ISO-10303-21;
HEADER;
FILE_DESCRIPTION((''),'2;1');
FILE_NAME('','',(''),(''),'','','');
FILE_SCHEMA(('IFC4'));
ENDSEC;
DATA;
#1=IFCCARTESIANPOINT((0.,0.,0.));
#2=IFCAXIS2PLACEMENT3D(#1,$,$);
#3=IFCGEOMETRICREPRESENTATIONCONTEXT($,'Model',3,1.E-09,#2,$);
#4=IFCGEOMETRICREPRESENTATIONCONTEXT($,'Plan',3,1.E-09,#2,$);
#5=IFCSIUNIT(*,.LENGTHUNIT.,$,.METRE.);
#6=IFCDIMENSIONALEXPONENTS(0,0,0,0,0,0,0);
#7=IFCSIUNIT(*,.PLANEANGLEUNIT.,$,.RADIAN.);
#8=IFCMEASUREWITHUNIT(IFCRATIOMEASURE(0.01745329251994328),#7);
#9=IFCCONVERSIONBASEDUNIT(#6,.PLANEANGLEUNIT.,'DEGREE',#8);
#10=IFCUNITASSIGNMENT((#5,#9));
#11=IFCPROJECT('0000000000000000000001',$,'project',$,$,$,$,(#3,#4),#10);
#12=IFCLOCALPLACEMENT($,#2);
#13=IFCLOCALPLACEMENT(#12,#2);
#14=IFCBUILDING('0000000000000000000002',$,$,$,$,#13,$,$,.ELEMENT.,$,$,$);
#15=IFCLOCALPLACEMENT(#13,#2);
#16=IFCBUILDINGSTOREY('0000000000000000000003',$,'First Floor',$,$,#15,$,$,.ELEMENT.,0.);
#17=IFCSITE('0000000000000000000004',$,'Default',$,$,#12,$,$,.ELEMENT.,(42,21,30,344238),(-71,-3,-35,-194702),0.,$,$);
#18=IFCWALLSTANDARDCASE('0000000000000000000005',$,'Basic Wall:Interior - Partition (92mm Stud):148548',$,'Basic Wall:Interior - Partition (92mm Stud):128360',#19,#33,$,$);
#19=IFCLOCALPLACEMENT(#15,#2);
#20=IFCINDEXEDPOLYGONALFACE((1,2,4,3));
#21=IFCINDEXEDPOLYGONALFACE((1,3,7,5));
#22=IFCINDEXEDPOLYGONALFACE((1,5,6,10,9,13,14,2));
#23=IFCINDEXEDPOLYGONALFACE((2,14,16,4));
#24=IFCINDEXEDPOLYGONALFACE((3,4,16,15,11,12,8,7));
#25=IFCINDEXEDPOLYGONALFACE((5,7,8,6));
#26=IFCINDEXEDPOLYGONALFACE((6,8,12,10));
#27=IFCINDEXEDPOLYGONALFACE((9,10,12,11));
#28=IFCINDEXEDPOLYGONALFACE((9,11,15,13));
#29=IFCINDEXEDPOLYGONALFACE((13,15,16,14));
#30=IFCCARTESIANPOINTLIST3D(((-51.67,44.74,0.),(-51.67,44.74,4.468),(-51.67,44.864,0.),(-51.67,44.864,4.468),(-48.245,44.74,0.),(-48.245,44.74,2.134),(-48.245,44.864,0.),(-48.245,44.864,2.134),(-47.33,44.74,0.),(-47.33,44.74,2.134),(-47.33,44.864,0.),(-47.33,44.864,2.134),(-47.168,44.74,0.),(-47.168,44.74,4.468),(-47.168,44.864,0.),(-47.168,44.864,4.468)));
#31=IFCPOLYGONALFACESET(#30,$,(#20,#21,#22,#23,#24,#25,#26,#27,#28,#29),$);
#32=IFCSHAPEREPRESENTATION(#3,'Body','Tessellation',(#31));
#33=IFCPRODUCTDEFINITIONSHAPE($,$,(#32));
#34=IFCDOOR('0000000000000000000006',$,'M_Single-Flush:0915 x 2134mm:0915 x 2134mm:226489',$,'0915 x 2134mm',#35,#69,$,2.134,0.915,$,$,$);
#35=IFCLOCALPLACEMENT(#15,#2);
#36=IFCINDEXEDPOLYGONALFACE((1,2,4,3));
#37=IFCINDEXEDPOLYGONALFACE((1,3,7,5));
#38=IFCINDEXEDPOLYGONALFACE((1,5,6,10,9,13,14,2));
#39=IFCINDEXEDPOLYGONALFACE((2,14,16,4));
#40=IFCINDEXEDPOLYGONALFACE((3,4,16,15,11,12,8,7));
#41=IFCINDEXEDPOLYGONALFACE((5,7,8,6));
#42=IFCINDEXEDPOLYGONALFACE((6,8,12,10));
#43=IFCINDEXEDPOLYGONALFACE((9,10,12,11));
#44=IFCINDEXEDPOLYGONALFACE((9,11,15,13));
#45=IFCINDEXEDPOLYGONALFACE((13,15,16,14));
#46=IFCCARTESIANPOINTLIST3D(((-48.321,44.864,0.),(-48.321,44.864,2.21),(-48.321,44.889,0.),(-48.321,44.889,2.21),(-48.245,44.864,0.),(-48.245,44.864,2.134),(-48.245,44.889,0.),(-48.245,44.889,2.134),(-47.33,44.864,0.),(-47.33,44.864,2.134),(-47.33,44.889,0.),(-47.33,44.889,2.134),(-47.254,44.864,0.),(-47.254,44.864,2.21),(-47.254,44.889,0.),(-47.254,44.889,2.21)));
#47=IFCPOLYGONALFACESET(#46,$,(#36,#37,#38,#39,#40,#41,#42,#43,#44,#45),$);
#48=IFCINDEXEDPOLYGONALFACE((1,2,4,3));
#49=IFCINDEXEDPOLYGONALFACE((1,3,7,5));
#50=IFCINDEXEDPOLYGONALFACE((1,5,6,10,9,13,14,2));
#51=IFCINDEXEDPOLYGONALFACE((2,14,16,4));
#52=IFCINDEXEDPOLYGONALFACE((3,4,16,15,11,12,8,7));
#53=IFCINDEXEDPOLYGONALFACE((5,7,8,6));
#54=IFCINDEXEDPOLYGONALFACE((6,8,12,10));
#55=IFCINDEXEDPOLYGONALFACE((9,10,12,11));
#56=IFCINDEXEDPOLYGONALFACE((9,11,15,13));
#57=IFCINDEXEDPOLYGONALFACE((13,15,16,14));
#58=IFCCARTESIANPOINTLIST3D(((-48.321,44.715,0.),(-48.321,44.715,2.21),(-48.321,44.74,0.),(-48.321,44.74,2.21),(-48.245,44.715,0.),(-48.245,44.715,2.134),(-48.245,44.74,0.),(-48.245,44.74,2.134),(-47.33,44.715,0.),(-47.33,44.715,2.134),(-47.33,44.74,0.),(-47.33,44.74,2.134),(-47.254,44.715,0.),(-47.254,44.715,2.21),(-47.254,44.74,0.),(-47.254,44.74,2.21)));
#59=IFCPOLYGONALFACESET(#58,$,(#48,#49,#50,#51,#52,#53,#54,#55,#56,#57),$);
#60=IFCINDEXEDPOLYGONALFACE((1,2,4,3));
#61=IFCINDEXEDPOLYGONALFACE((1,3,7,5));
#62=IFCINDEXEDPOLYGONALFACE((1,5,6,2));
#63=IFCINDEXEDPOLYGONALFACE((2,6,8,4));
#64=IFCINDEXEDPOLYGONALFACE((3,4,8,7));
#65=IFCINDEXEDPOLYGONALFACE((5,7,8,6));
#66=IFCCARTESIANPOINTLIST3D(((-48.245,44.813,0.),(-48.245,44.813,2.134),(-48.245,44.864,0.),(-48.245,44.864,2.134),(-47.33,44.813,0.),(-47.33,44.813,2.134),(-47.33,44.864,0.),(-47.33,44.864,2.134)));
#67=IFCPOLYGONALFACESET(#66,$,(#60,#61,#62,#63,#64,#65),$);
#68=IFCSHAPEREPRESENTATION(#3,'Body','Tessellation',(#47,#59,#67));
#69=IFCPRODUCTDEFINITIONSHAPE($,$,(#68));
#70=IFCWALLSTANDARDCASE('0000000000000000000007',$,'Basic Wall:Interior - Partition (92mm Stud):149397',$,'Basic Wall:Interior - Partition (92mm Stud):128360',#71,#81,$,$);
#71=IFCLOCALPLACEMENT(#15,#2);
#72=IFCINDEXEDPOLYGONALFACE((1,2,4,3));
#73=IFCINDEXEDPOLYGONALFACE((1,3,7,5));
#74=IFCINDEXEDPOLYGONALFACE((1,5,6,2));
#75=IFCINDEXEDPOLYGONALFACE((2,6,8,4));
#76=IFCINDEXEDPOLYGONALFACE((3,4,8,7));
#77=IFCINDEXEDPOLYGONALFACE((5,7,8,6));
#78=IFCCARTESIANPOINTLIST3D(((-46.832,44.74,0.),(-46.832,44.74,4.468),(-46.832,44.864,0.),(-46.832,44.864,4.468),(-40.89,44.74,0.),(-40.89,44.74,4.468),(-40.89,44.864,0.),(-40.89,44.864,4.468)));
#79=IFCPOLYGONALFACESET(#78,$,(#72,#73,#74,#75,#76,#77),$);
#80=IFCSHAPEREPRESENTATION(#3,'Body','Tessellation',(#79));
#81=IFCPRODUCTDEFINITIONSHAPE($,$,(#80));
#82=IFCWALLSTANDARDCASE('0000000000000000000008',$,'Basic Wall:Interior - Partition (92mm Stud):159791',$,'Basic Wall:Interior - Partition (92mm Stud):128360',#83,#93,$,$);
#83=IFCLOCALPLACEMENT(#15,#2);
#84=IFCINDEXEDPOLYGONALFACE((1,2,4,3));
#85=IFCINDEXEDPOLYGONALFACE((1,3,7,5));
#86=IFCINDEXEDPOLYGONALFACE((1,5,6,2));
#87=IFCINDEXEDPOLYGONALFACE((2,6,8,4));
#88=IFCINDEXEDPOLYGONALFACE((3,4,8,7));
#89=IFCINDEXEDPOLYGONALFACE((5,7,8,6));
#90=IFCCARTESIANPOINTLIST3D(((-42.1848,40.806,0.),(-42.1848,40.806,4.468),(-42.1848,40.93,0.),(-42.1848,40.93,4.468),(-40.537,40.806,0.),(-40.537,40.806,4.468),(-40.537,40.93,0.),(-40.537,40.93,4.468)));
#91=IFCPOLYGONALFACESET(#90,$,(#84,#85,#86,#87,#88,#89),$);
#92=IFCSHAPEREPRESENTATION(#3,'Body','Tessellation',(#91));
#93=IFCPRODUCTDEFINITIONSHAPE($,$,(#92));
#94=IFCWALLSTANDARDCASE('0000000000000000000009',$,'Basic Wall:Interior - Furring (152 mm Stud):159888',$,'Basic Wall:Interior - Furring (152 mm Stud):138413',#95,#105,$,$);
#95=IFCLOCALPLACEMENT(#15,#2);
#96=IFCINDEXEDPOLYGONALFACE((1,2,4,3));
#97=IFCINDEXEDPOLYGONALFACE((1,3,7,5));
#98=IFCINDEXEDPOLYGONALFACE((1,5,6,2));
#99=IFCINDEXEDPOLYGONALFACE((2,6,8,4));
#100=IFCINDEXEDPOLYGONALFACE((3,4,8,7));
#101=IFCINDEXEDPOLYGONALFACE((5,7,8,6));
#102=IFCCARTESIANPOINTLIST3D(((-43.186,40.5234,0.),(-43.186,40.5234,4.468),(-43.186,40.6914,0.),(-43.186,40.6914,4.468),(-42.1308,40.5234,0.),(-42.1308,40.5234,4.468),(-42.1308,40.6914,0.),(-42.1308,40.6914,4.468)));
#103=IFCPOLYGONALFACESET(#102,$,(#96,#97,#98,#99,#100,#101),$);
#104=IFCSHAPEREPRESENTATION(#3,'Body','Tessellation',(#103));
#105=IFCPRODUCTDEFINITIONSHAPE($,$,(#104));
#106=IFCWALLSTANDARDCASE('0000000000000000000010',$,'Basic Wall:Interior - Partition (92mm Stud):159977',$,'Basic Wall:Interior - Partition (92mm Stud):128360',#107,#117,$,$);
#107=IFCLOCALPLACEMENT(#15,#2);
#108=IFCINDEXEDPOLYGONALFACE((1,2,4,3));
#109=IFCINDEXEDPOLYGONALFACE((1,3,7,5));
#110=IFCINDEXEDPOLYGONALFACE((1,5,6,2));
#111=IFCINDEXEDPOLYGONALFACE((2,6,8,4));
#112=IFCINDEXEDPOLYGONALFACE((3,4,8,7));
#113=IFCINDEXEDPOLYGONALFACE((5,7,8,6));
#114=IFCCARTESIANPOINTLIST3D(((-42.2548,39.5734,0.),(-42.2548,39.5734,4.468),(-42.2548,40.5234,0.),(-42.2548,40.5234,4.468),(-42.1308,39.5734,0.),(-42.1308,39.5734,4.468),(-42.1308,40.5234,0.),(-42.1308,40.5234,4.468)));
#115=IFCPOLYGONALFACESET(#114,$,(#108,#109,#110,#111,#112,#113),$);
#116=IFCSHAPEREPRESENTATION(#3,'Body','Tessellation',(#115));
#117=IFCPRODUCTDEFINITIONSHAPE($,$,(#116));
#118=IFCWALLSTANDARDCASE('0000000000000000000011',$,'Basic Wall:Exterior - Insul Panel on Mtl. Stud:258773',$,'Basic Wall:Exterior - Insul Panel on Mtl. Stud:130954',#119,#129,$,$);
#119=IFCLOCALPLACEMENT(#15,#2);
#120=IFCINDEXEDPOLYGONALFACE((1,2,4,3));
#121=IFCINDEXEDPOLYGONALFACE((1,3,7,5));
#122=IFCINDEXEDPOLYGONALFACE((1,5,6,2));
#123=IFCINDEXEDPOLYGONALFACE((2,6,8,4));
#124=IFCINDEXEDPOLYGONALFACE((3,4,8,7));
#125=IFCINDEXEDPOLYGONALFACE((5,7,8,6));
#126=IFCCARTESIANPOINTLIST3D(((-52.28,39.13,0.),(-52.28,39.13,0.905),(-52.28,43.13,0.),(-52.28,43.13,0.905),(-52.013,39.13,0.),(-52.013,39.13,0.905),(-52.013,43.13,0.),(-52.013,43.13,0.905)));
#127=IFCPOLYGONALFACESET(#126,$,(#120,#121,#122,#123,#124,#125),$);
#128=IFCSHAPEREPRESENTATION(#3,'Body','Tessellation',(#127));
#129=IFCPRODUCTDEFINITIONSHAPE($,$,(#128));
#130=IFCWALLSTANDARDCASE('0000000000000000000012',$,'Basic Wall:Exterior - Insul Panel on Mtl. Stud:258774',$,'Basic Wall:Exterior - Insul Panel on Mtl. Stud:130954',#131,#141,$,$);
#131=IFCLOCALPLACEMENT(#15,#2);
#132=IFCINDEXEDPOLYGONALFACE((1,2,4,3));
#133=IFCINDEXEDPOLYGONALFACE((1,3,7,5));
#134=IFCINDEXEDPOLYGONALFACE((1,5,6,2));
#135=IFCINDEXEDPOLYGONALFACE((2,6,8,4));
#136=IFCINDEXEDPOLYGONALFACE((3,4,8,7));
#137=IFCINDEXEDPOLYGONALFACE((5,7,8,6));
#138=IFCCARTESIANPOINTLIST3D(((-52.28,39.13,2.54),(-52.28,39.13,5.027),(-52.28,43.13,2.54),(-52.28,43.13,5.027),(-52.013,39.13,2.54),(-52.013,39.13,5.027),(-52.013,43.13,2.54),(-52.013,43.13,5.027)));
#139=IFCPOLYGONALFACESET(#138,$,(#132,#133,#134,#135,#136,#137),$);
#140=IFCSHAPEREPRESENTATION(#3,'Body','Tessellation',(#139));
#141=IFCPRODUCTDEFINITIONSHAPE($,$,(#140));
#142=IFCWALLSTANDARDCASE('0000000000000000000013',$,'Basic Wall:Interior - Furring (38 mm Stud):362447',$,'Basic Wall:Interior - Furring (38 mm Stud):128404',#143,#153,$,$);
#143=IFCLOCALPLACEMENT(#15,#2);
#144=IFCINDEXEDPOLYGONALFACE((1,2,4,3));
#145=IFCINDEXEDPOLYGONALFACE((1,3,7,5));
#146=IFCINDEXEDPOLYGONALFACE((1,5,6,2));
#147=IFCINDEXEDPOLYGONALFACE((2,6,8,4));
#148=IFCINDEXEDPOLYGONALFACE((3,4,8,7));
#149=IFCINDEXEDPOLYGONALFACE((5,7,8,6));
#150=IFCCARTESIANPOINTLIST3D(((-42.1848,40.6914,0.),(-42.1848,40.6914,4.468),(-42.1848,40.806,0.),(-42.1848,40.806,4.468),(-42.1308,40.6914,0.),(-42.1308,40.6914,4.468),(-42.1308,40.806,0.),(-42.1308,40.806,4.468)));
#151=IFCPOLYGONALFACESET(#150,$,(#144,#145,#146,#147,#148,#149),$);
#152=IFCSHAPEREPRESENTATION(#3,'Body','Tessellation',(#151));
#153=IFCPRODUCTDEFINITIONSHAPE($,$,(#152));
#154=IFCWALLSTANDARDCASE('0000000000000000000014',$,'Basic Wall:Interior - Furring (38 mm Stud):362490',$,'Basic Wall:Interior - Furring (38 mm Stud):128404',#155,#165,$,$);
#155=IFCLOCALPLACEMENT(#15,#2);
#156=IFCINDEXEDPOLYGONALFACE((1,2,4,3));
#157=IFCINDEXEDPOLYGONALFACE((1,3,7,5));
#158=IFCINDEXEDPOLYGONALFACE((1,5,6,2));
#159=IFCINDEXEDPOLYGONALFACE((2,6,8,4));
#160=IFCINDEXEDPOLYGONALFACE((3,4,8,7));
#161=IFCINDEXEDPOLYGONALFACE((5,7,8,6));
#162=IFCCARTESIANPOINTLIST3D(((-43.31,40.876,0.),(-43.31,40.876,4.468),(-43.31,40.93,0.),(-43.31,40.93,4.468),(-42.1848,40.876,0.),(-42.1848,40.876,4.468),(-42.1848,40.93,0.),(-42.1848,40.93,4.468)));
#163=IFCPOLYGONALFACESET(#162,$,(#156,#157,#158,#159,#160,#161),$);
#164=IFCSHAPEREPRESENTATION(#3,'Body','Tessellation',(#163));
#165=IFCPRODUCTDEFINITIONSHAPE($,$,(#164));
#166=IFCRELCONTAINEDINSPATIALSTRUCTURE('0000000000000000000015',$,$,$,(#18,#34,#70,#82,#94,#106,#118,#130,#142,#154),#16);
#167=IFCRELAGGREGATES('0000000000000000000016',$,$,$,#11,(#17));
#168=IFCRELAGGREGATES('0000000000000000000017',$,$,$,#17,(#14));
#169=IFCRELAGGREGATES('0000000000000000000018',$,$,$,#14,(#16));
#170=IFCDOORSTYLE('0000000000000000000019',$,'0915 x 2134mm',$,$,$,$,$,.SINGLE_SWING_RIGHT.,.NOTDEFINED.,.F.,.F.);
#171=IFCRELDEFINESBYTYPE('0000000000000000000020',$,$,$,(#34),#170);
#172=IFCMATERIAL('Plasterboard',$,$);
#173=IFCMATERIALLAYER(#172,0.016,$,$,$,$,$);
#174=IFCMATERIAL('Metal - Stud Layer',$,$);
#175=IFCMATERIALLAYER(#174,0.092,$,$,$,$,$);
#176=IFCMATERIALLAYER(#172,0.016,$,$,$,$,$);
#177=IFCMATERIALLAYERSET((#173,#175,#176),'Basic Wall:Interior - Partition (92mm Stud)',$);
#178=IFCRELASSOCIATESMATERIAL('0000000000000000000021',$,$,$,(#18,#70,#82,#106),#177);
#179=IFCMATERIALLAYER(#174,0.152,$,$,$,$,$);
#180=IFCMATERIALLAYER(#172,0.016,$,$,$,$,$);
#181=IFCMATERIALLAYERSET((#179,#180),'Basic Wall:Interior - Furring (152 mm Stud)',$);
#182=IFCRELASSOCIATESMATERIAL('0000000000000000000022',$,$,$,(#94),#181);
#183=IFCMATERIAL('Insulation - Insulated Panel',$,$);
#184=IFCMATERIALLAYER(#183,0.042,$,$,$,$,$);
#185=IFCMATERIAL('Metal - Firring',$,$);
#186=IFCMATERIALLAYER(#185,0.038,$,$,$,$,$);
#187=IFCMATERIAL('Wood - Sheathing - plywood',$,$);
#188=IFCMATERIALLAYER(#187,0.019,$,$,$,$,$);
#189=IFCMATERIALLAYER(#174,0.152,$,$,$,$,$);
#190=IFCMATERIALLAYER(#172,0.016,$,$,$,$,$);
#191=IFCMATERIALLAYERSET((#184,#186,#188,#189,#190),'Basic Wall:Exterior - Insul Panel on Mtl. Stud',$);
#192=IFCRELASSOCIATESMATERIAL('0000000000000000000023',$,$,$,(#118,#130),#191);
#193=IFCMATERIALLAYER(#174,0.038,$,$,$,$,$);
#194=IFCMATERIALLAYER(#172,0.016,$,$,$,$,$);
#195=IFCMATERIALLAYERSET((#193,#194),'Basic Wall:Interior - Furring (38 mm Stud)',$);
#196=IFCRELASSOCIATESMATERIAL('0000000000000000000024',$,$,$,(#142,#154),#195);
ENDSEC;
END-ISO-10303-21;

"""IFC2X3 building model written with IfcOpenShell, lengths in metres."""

from ifc_helpers import new_model, entity, si_unit, converted_unit, frame, frame_2d, origin, origin_2d_with_axis, place, context, project, spatial, polyline, rectangle, outline, extrude, source, transform, mapped, material, layer, layer_set, layer_usage, type_object, type_shapes, element, fill, save


model = new_model("IFC2X3")

# Units and contexts
model_context = context("Model", 3, precision=1e-09, world=origin())
plan_context = context("Plan", 3, precision=1e-09, world=origin())
ifc_project = project(units=[si_unit("LENGTHUNIT", "METRE"), converted_unit("PLANEANGLEUNIT", "DEGREE", entity("IfcRatioMeasure", 0.01745329251994328), si_unit("PLANEANGLEUNIT", "RADIAN"), dimensions=[0, 0, 0, 0, 0, 0, 0])], contexts=[model_context, plan_context])

# Site, building, storey
site_placement = place(None, origin())
site = spatial("IfcSite", under=ifc_project, at=site_placement, Name="Default", CompositionType="ELEMENT", RefLatitude=(42, 21, 30, 344238), RefLongitude=(-71, -3, -35, -194702), RefElevation=0.0)
building_placement = place(site_placement, origin())
building = spatial("IfcBuilding", under=site, at=building_placement, CompositionType="ELEMENT")
storey_placement = place(building_placement, origin())
storey = spatial("IfcBuildingStorey", under=building, at=storey_placement, Name="First Floor", CompositionType="ELEMENT", Elevation=0.0)

# Wall, opening, door
ifc_material_1 = material(Name="Plasterboard")
ifc_layer_1 = layer(ifc_material_1, 0.016)
ifc_material_2 = material(Name="Metal - Stud Layer")
ifc_layer_2 = layer(ifc_material_2, 0.092)
ifc_layer_3 = layer(ifc_material_1, 0.016)
ifc_layer_set_1 = layer_set([ifc_layer_1, ifc_layer_2, ifc_layer_3], Name="Basic Wall:Interior - Partition (92mm Stud)")
ifc_layer_usage_1 = layer_usage(ifc_layer_set_1, "AXIS2", "NEGATIVE", 0.062)
wall_1_placement = place(storey_placement, frame((-47.168, 44.802, 0.0), z_axis=(0.0, 0.0, 1.0), x_axis=(-1.0, 0.0, 0.0)))
wall_1 = element("IfcWallStandardCase", 1, at=wall_1_placement, inside=storey, material=ifc_layer_usage_1, Name="Basic Wall:Interior - Partition (92mm Stud):148548", ObjectType="Basic Wall:Interior - Partition (92mm Stud):128360", context=model_context, shape_type="SweptSolid", body=[
    extrude(rectangle(XDim=4.502, YDim=0.124, at=frame_2d((2.251, 0.0), x_axis=(-1.0, 0.0))), origin(), (0.0, 0.0, 1.0), 4.468),
])
opening_placement = place(wall_1_placement, frame((1.077, 0.062, 0.0)))
opening = element("IfcOpeningElement", 2, at=opening_placement, cuts=wall_1, ObjectType="Opening", context=model_context, shape_type="SweptSolid", body=[
    extrude(rectangle(XDim=0.915, YDim=2.134, at=frame_2d((1.067, 0.4575), x_axis=(0.0, 1.0))), frame((0.0, 0.0, 0.0), z_axis=(0.0, -1.0, 0.0), x_axis=(0.0, 0.0, 1.0)), (0.0, 0.0, 1.0), 0.124),
])
door_style = type_object("IfcDoorStyle", Name="0915 x 2134mm", ConstructionType="NOTDEFINED", OperationType="SINGLE_SWING_RIGHT", ParameterTakesPrecedence=False, Sizeable=False)
shared_shape_1 = source(origin(), model_context, "Body", "SweptSolid", [
    extrude(outline(polyline([(-0.5335, -1.124), (0.5335, -1.124), (0.5335, 1.086), (0.4575, 1.086), (0.4575, -1.048), (-0.4575, -1.048), (-0.4575, 1.086), (-0.5335, 1.086), (-0.5335, -1.124)])), frame((0.4575, 0.124, 1.086), z_axis=(0.0, 1.0, 0.0), x_axis=(1.0, 0.0, 0.0)), (0.0, 0.0, 1.0), 0.025),
    extrude(outline(polyline([(-1.124, -0.5335), (1.086, -0.5335), (1.086, -0.4575), (-1.048, -0.4575), (-1.048, 0.4575), (1.086, 0.4575), (1.086, 0.5335), (-1.124, 0.5335), (-1.124, -0.5335)])), frame((0.4575, -0.025, 1.086), z_axis=(0.0, 1.0, 0.0), x_axis=(0.0, 0.0, -1.0)), (0.0, 0.0, 1.0), 0.025),
    extrude(rectangle(XDim=0.051, YDim=0.915, at=origin_2d_with_axis()), frame((0.4575, 0.0985, 0.0), z_axis=(0.0, 0.0, 1.0), x_axis=(0.0, 1.0, 0.0)), (0.0, 0.0, 1.0), 2.134),
])
type_shapes(door_style, [shared_shape_1])
door_placement = place(opening_placement, frame((0.0, 0.0, 0.0), z_axis=(0.0, 0.0, 1.0), x_axis=(-1.0, 0.0, 0.0)))
door = element("IfcDoor", 3, at=door_placement, inside=storey, type_object=door_style, Name="M_Single-Flush:0915 x 2134mm:0915 x 2134mm:226489", ObjectType="0915 x 2134mm", OverallHeight=2.134, OverallWidth=0.915, context=model_context, shape_type="MappedRepresentation", body=[
    mapped(shared_shape_1, transform((0.0, 0.0, 0.0), scale=1.0)),
])
fill(opening, door)

# Walls
ifc_layer_usage_2 = layer_usage(ifc_layer_set_1, "AXIS2", "NEGATIVE", 0.062)
wall_2_placement = place(storey_placement, frame((-40.89, 44.802, 0.0), z_axis=(0.0, 0.0, 1.0), x_axis=(-1.0, 0.0, 0.0)))
element("IfcWallStandardCase", 4, at=wall_2_placement, inside=storey, material=ifc_layer_usage_2, Name="Basic Wall:Interior - Partition (92mm Stud):149397", ObjectType="Basic Wall:Interior - Partition (92mm Stud):128360", context=model_context, shape_type="SweptSolid", body=[
    extrude(rectangle(XDim=5.942, YDim=0.124, at=frame_2d((2.971, 0.0), x_axis=(-1.0, 0.0))), origin(), (0.0, 0.0, 1.0), 4.468),
])
ifc_layer_usage_3 = layer_usage(ifc_layer_set_1, "AXIS2", "NEGATIVE", 0.062)
wall_3_placement = place(storey_placement, frame((-42.1848, 40.868, 0.0)))
element("IfcWallStandardCase", 5, at=wall_3_placement, inside=storey, material=ifc_layer_usage_3, Name="Basic Wall:Interior - Partition (92mm Stud):159791", ObjectType="Basic Wall:Interior - Partition (92mm Stud):128360", context=model_context, shape_type="SweptSolid", body=[
    extrude(rectangle(XDim=1.6478, YDim=0.124, at=frame_2d((0.8239, 0.0), x_axis=(-1.0, 0.0))), origin(), (0.0, 0.0, 1.0), 4.468),
])
ifc_layer_4 = layer(ifc_material_2, 0.152)
ifc_layer_5 = layer(ifc_material_1, 0.016)
ifc_layer_set_2 = layer_set([ifc_layer_4, ifc_layer_5], Name="Basic Wall:Interior - Furring (152 mm Stud)")
ifc_layer_usage_4 = layer_usage(ifc_layer_set_2, "AXIS2", "POSITIVE", -0.084)
wall_4_placement = place(storey_placement, frame((-42.1308, 40.6074, 0.0), z_axis=(0.0, 0.0, 1.0), x_axis=(-1.0, 0.0, 0.0)))
element("IfcWallStandardCase", 6, at=wall_4_placement, inside=storey, material=ifc_layer_usage_4, Name="Basic Wall:Interior - Furring (152 mm Stud):159888", ObjectType="Basic Wall:Interior - Furring (152 mm Stud):138413", context=model_context, shape_type="SweptSolid", body=[
    extrude(rectangle(XDim=1.0552, YDim=0.168, at=frame_2d((0.5276, 0.0), x_axis=(-1.0, 0.0))), origin(), (0.0, 0.0, 1.0), 4.468),
])
ifc_layer_usage_5 = layer_usage(ifc_layer_set_1, "AXIS2", "NEGATIVE", 0.062)
wall_5_placement = place(storey_placement, frame((-42.1928, 39.5734, 0.0), z_axis=(0.0, 0.0, 1.0), x_axis=(0.0, 1.0, 0.0)))
element("IfcWallStandardCase", 7, at=wall_5_placement, inside=storey, material=ifc_layer_usage_5, Name="Basic Wall:Interior - Partition (92mm Stud):159977", ObjectType="Basic Wall:Interior - Partition (92mm Stud):128360", context=model_context, shape_type="SweptSolid", body=[
    extrude(rectangle(XDim=0.95, YDim=0.124, at=frame_2d((0.475, 0.0), x_axis=(-1.0, 0.0))), origin(), (0.0, 0.0, 1.0), 4.468),
])
ifc_material_3 = material(Name="Insulation - Insulated Panel")
ifc_layer_6 = layer(ifc_material_3, 0.042)
ifc_material_4 = material(Name="Metal - Firring")
ifc_layer_7 = layer(ifc_material_4, 0.038)
ifc_material_5 = material(Name="Wood - Sheathing - plywood")
ifc_layer_8 = layer(ifc_material_5, 0.019)
ifc_layer_9 = layer(ifc_material_2, 0.152)
ifc_layer_10 = layer(ifc_material_1, 0.016)
ifc_layer_set_3 = layer_set([ifc_layer_6, ifc_layer_7, ifc_layer_8, ifc_layer_9, ifc_layer_10], Name="Basic Wall:Exterior - Insul Panel on Mtl. Stud")
ifc_layer_usage_6 = layer_usage(ifc_layer_set_3, "AXIS2", "NEGATIVE", 0.1335)
wall_6_placement = place(storey_placement, frame((-52.1465, 39.13, 0.0), z_axis=(0.0, 0.0, 1.0), x_axis=(0.0, 1.0, 0.0)))
element("IfcWallStandardCase", 8, at=wall_6_placement, inside=storey, material=ifc_layer_usage_6, Name="Basic Wall:Exterior - Insul Panel on Mtl. Stud:258773", ObjectType="Basic Wall:Exterior - Insul Panel on Mtl. Stud:130954", context=model_context, shape_type="SweptSolid", body=[
    extrude(rectangle(XDim=4.0, YDim=0.267, at=frame_2d((2.0, 0.0), x_axis=(-1.0, 0.0))), origin(), (0.0, 0.0, 1.0), 0.905),
])
ifc_layer_usage_7 = layer_usage(ifc_layer_set_3, "AXIS2", "NEGATIVE", 0.1335)
wall_7_placement = place(storey_placement, frame((-52.1465, 39.13, 2.54), z_axis=(0.0, 0.0, 1.0), x_axis=(0.0, 1.0, 0.0)))
element("IfcWallStandardCase", 9, at=wall_7_placement, inside=storey, material=ifc_layer_usage_7, Name="Basic Wall:Exterior - Insul Panel on Mtl. Stud:258774", ObjectType="Basic Wall:Exterior - Insul Panel on Mtl. Stud:130954", context=model_context, shape_type="SweptSolid", body=[
    extrude(rectangle(XDim=4.0, YDim=0.267, at=frame_2d((2.0, 0.0), x_axis=(-1.0, 0.0))), origin(), (0.0, 0.0, 1.0), 2.487),
])
ifc_layer_11 = layer(ifc_material_2, 0.038)
ifc_layer_12 = layer(ifc_material_1, 0.016)
ifc_layer_set_4 = layer_set([ifc_layer_11, ifc_layer_12], Name="Basic Wall:Interior - Furring (38 mm Stud)")
ifc_layer_usage_8 = layer_usage(ifc_layer_set_4, "AXIS2", "NEGATIVE", 0.027)
wall_8_placement = place(storey_placement, frame((-42.1578, 40.6914, 0.0), z_axis=(0.0, 0.0, 1.0), x_axis=(0.0, 1.0, 0.0)))
element("IfcWallStandardCase", 10, at=wall_8_placement, inside=storey, material=ifc_layer_usage_8, Name="Basic Wall:Interior - Furring (38 mm Stud):362447", ObjectType="Basic Wall:Interior - Furring (38 mm Stud):128404", context=model_context, shape_type="SweptSolid", body=[
    extrude(rectangle(XDim=0.1146, YDim=0.054, at=frame_2d((0.0573, 0.0), x_axis=(-1.0, 0.0))), origin(), (0.0, 0.0, 1.0), 4.468),
])
ifc_layer_usage_9 = layer_usage(ifc_layer_set_4, "AXIS2", "NEGATIVE", 0.027)
wall_9_placement = place(storey_placement, frame((-42.1848, 40.903, 0.0), z_axis=(0.0, 0.0, 1.0), x_axis=(-1.0, 0.0, 0.0)))
element("IfcWallStandardCase", 11, at=wall_9_placement, inside=storey, material=ifc_layer_usage_9, Name="Basic Wall:Interior - Furring (38 mm Stud):362490", ObjectType="Basic Wall:Interior - Furring (38 mm Stud):128404", context=model_context, shape_type="SweptSolid", body=[
    extrude(rectangle(XDim=1.1252, YDim=0.054, at=frame_2d((0.5626, 0.0), x_axis=(-1.0, 0.0))), origin(), (0.0, 0.0, 1.0), 4.468),
])

save(model, "model.ifc")
